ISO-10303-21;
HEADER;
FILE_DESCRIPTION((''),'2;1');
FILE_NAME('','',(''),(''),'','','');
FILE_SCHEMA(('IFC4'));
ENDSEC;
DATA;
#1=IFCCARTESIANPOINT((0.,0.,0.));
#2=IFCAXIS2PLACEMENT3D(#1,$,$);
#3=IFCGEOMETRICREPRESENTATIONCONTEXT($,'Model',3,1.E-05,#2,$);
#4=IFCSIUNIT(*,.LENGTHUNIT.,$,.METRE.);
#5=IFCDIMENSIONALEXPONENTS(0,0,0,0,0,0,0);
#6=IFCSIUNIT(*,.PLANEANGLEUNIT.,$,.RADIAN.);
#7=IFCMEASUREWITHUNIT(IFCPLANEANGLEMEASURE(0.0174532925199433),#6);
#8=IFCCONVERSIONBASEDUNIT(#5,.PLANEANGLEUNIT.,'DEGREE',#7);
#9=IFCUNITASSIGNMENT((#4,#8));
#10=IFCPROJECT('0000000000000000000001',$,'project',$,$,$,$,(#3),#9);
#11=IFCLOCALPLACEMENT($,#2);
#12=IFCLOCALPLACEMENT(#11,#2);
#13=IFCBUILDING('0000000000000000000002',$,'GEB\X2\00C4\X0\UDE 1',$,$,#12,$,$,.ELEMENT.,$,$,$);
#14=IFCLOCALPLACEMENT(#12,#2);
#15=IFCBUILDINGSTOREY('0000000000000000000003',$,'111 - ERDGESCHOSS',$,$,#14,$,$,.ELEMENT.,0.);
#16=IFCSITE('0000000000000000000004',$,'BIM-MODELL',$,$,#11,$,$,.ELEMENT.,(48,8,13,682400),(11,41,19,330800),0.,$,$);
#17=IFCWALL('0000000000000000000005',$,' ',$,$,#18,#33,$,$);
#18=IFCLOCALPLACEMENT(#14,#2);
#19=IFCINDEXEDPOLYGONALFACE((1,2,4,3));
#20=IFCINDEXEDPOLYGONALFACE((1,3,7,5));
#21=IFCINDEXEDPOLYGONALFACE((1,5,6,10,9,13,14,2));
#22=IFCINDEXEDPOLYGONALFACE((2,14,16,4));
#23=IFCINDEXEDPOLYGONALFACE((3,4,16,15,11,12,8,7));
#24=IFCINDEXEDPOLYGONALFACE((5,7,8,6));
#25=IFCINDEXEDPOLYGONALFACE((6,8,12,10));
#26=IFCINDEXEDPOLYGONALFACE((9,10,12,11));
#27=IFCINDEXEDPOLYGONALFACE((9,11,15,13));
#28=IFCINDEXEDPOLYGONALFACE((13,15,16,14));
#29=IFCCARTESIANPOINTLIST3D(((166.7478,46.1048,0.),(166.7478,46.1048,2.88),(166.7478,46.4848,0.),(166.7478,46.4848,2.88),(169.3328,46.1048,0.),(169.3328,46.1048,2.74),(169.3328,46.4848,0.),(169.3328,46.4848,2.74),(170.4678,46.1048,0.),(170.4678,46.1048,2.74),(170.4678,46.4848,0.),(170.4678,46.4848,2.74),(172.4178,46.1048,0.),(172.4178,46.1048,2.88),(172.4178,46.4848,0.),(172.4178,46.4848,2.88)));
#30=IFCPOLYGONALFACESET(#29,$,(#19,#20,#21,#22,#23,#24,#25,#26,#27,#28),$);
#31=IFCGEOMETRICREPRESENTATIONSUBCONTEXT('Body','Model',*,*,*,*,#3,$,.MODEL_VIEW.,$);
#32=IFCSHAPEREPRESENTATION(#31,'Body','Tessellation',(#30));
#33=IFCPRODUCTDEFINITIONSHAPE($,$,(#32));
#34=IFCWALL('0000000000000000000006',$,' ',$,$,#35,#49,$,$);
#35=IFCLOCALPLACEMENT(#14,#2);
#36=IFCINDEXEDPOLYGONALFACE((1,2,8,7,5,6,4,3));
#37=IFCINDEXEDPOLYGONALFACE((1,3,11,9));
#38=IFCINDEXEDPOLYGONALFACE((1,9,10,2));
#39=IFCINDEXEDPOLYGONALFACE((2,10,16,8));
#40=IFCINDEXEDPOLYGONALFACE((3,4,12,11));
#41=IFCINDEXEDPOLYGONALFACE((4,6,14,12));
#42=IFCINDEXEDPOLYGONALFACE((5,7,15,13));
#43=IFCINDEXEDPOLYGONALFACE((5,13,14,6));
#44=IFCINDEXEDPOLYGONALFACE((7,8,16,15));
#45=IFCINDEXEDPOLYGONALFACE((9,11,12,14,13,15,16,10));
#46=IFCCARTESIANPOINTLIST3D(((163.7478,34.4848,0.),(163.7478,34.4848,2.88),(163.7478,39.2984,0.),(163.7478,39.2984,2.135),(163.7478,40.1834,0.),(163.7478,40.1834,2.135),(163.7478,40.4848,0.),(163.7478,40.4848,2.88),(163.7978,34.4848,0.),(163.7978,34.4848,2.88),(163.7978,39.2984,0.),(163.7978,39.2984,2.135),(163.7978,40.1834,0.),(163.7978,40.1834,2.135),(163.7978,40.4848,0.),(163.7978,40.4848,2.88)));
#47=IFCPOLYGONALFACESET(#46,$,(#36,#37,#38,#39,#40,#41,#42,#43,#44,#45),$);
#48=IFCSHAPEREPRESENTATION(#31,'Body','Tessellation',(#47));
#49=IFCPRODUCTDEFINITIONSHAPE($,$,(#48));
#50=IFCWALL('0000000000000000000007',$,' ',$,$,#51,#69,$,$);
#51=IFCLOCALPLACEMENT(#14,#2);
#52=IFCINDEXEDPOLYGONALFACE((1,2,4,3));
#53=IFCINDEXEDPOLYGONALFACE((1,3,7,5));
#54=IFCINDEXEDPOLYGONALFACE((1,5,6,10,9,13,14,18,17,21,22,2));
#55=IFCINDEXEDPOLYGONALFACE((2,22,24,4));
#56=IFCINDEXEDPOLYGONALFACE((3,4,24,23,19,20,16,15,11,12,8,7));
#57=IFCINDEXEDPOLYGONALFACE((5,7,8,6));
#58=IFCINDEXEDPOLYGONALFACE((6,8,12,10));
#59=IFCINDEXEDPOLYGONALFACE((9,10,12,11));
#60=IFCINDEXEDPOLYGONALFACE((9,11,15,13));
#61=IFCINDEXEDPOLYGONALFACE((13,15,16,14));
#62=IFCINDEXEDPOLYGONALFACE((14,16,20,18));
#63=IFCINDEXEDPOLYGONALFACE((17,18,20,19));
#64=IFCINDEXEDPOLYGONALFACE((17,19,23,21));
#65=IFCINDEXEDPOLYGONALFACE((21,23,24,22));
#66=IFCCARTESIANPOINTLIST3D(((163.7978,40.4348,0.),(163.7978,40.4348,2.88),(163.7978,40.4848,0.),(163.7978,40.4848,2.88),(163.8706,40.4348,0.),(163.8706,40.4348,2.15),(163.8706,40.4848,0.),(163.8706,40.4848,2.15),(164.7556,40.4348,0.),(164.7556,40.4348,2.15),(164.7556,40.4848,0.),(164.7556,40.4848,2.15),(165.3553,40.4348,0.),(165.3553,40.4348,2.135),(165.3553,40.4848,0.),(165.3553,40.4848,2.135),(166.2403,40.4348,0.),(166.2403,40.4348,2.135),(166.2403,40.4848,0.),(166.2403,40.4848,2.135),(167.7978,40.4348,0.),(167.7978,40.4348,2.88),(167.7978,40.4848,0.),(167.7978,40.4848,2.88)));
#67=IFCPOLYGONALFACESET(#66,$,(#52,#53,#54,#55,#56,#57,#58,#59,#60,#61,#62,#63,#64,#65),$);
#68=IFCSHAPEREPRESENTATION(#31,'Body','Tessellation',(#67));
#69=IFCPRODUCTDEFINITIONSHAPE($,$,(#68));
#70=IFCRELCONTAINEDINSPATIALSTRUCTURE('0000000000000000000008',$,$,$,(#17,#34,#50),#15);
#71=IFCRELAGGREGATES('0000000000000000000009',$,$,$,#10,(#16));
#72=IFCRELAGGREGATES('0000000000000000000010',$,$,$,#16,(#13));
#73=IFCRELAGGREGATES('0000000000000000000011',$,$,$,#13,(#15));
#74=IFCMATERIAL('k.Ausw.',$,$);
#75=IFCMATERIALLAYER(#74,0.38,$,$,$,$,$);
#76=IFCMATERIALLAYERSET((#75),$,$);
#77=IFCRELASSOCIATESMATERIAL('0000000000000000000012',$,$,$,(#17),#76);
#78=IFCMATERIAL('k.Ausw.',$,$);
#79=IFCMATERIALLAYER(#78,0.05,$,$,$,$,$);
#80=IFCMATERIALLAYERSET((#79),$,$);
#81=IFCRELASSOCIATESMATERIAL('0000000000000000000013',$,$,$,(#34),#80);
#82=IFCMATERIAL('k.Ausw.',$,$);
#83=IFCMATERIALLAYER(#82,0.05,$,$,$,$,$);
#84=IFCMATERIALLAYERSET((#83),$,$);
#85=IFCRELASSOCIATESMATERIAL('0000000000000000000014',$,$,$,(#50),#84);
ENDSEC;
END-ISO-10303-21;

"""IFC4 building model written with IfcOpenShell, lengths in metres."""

from ifc_helpers import new_model, entity, si_unit, converted_unit, frame, frame_2d, origin, origin_with_axes, place, context, subcontext, project, spatial, polyline, rectangle, outline, extrude, material, layer, layer_set, layer_usage, element, save


model = new_model("IFC4")

# Units and contexts
model_context = context("Model", 3, precision=1e-05, world=origin())
body_context = subcontext(model_context, "Body", "Model", "MODEL_VIEW")
ifc_project = project(units=[si_unit("LENGTHUNIT", "METRE"), converted_unit("PLANEANGLEUNIT", "DEGREE", entity("IfcPlaneAngleMeasure", 0.0174532925199433), si_unit("PLANEANGLEUNIT", "RADIAN"), dimensions=[0, 0, 0, 0, 0, 0, 0])], contexts=[model_context])

# Site, building, storey
site_placement = place(None, origin())
site = spatial("IfcSite", under=ifc_project, at=site_placement, Name="BIM-MODELL", CompositionType="ELEMENT", RefLatitude=(48, 8, 13, 682400), RefLongitude=(11, 41, 19, 330800), RefElevation=0.0)
building_placement = place(site_placement, origin())
building = spatial("IfcBuilding", under=site, at=building_placement, Name="GEBÄUDE 1", CompositionType="ELEMENT")
storey_placement = place(building_placement, origin())
storey = spatial("IfcBuildingStorey", under=building, at=storey_placement, Name="111 - ERDGESCHOSS", CompositionType="ELEMENT", Elevation=0.0)

# Walls, openings
ifc_material_1 = material(Name="k.Ausw.")
ifc_layer_1 = layer(ifc_material_1, 0.38)
ifc_layer_set_1 = layer_set([ifc_layer_1])
ifc_layer_usage_1 = layer_usage(ifc_layer_set_1, "AXIS2", "POSITIVE", 0.0)
wall_1_placement = place(storey_placement, frame((172.4178, 46.4848, 0.0), z_axis=(0.0, 0.0, 1.0), x_axis=(-1.0, 0.0, 0.0)))
wall_1 = element("IfcWall", 1, at=wall_1_placement, inside=storey, material=ifc_layer_usage_1, Name=" ", context=body_context, shape_type="SweptSolid", body=[
    extrude(rectangle(XDim=5.67, YDim=0.38, at=frame_2d((2.835, 0.19), x_axis=(1.0, 0.0))), origin_with_axes(), (0.0, 0.0, 1.0), 2.88),
])
opening_1_placement = place(wall_1_placement, frame((3.085, 0.38, 0.0), z_axis=(0.0, -1.0, 0.0), x_axis=(0.0, 0.0, 1.0)))
element("IfcOpeningElement", 2, at=opening_1_placement, cuts=wall_1, ObjectType="Opening", context=body_context, shape_type="SweptSolid", body=[
    extrude(outline(polyline([(0.0, 1.135), (2.74, 1.135), (2.74, 0.0), (0.0, 0.0), (0.0, 1.135)])), origin_with_axes(), (0.0, 0.0, 1.0), 0.38),
])
ifc_material_2 = material(Name="k.Ausw.")
ifc_layer_2 = layer(ifc_material_2, 0.05)
ifc_layer_set_2 = layer_set([ifc_layer_2])
ifc_layer_usage_2 = layer_usage(ifc_layer_set_2, "AXIS2", "POSITIVE", 0.0)
wall_2_placement = place(storey_placement, frame((163.7478, 40.4848, 0.0), z_axis=(0.0, 0.0, 1.0), x_axis=(0.0, -1.0, 0.0)))
wall_2 = element("IfcWall", 3, at=wall_2_placement, inside=storey, material=ifc_layer_usage_2, Name=" ", context=body_context, shape_type="SweptSolid", body=[
    extrude(rectangle(XDim=6.0, YDim=0.05, at=frame_2d((3.0, 0.025), x_axis=(1.0, 0.0))), origin_with_axes(), (0.0, 0.0, 1.0), 2.88),
])
opening_2_placement = place(wall_2_placement, frame((0.3014, 0.0, 0.0), z_axis=(0.0, 1.0, 0.0), x_axis=(0.0, 0.0, 1.0)))
element("IfcOpeningElement", 4, at=opening_2_placement, cuts=wall_2, ObjectType="Opening", context=body_context, shape_type="SweptSolid", body=[
    extrude(outline(polyline([(0.0, 0.885), (2.135, 0.885), (2.135, 0.0), (0.0, 0.0), (0.0, 0.885)])), origin_with_axes(), (0.0, 0.0, 1.0), 0.05),
])

# Wall, openings
ifc_material_3 = material(Name="k.Ausw.")
ifc_layer_3 = layer(ifc_material_3, 0.05)
ifc_layer_set_3 = layer_set([ifc_layer_3])
ifc_layer_usage_3 = layer_usage(ifc_layer_set_3, "AXIS2", "POSITIVE", 0.0)
wall_3_placement = place(storey_placement, frame((167.7978, 40.4848, 0.0), z_axis=(0.0, 0.0, 1.0), x_axis=(-1.0, 0.0, 0.0)))
wall_3 = element("IfcWall", 5, at=wall_3_placement, inside=storey, material=ifc_layer_usage_3, Name=" ", context=body_context, shape_type="SweptSolid", body=[
    extrude(rectangle(XDim=4.0, YDim=0.05, at=frame_2d((2.0, 0.025), x_axis=(1.0, 0.0))), origin_with_axes(), (0.0, 0.0, 1.0), 2.88),
])
opening_3_placement = place(wall_3_placement, frame((3.9272, 0.05, -0.15), z_axis=(0.0, -1.0, 0.0), x_axis=(0.0, 0.0, 1.0)))
element("IfcOpeningElement", 6, at=opening_3_placement, cuts=wall_3, ObjectType="Opening", context=body_context, shape_type="SweptSolid", body=[
    extrude(outline(polyline([(0.0, 0.885), (2.3, 0.885), (2.3, 0.0), (0.0, 0.0), (0.0, 0.885)])), origin_with_axes(), (0.0, 0.0, 1.0), 0.05),
])
opening_4_placement = place(wall_3_placement, frame((1.5575, 0.0, 0.0), z_axis=(0.0, 1.0, 0.0), x_axis=(0.0, 0.0, 1.0)))
element("IfcOpeningElement", 7, at=opening_4_placement, cuts=wall_3, ObjectType="Opening", context=body_context, shape_type="SweptSolid", body=[
    extrude(outline(polyline([(0.0, 0.885), (2.135, 0.885), (2.135, 0.0), (0.0, 0.0), (0.0, 0.885)])), origin_with_axes(), (0.0, 0.0, 1.0), 0.05),
])

save(model, "model.ifc")
